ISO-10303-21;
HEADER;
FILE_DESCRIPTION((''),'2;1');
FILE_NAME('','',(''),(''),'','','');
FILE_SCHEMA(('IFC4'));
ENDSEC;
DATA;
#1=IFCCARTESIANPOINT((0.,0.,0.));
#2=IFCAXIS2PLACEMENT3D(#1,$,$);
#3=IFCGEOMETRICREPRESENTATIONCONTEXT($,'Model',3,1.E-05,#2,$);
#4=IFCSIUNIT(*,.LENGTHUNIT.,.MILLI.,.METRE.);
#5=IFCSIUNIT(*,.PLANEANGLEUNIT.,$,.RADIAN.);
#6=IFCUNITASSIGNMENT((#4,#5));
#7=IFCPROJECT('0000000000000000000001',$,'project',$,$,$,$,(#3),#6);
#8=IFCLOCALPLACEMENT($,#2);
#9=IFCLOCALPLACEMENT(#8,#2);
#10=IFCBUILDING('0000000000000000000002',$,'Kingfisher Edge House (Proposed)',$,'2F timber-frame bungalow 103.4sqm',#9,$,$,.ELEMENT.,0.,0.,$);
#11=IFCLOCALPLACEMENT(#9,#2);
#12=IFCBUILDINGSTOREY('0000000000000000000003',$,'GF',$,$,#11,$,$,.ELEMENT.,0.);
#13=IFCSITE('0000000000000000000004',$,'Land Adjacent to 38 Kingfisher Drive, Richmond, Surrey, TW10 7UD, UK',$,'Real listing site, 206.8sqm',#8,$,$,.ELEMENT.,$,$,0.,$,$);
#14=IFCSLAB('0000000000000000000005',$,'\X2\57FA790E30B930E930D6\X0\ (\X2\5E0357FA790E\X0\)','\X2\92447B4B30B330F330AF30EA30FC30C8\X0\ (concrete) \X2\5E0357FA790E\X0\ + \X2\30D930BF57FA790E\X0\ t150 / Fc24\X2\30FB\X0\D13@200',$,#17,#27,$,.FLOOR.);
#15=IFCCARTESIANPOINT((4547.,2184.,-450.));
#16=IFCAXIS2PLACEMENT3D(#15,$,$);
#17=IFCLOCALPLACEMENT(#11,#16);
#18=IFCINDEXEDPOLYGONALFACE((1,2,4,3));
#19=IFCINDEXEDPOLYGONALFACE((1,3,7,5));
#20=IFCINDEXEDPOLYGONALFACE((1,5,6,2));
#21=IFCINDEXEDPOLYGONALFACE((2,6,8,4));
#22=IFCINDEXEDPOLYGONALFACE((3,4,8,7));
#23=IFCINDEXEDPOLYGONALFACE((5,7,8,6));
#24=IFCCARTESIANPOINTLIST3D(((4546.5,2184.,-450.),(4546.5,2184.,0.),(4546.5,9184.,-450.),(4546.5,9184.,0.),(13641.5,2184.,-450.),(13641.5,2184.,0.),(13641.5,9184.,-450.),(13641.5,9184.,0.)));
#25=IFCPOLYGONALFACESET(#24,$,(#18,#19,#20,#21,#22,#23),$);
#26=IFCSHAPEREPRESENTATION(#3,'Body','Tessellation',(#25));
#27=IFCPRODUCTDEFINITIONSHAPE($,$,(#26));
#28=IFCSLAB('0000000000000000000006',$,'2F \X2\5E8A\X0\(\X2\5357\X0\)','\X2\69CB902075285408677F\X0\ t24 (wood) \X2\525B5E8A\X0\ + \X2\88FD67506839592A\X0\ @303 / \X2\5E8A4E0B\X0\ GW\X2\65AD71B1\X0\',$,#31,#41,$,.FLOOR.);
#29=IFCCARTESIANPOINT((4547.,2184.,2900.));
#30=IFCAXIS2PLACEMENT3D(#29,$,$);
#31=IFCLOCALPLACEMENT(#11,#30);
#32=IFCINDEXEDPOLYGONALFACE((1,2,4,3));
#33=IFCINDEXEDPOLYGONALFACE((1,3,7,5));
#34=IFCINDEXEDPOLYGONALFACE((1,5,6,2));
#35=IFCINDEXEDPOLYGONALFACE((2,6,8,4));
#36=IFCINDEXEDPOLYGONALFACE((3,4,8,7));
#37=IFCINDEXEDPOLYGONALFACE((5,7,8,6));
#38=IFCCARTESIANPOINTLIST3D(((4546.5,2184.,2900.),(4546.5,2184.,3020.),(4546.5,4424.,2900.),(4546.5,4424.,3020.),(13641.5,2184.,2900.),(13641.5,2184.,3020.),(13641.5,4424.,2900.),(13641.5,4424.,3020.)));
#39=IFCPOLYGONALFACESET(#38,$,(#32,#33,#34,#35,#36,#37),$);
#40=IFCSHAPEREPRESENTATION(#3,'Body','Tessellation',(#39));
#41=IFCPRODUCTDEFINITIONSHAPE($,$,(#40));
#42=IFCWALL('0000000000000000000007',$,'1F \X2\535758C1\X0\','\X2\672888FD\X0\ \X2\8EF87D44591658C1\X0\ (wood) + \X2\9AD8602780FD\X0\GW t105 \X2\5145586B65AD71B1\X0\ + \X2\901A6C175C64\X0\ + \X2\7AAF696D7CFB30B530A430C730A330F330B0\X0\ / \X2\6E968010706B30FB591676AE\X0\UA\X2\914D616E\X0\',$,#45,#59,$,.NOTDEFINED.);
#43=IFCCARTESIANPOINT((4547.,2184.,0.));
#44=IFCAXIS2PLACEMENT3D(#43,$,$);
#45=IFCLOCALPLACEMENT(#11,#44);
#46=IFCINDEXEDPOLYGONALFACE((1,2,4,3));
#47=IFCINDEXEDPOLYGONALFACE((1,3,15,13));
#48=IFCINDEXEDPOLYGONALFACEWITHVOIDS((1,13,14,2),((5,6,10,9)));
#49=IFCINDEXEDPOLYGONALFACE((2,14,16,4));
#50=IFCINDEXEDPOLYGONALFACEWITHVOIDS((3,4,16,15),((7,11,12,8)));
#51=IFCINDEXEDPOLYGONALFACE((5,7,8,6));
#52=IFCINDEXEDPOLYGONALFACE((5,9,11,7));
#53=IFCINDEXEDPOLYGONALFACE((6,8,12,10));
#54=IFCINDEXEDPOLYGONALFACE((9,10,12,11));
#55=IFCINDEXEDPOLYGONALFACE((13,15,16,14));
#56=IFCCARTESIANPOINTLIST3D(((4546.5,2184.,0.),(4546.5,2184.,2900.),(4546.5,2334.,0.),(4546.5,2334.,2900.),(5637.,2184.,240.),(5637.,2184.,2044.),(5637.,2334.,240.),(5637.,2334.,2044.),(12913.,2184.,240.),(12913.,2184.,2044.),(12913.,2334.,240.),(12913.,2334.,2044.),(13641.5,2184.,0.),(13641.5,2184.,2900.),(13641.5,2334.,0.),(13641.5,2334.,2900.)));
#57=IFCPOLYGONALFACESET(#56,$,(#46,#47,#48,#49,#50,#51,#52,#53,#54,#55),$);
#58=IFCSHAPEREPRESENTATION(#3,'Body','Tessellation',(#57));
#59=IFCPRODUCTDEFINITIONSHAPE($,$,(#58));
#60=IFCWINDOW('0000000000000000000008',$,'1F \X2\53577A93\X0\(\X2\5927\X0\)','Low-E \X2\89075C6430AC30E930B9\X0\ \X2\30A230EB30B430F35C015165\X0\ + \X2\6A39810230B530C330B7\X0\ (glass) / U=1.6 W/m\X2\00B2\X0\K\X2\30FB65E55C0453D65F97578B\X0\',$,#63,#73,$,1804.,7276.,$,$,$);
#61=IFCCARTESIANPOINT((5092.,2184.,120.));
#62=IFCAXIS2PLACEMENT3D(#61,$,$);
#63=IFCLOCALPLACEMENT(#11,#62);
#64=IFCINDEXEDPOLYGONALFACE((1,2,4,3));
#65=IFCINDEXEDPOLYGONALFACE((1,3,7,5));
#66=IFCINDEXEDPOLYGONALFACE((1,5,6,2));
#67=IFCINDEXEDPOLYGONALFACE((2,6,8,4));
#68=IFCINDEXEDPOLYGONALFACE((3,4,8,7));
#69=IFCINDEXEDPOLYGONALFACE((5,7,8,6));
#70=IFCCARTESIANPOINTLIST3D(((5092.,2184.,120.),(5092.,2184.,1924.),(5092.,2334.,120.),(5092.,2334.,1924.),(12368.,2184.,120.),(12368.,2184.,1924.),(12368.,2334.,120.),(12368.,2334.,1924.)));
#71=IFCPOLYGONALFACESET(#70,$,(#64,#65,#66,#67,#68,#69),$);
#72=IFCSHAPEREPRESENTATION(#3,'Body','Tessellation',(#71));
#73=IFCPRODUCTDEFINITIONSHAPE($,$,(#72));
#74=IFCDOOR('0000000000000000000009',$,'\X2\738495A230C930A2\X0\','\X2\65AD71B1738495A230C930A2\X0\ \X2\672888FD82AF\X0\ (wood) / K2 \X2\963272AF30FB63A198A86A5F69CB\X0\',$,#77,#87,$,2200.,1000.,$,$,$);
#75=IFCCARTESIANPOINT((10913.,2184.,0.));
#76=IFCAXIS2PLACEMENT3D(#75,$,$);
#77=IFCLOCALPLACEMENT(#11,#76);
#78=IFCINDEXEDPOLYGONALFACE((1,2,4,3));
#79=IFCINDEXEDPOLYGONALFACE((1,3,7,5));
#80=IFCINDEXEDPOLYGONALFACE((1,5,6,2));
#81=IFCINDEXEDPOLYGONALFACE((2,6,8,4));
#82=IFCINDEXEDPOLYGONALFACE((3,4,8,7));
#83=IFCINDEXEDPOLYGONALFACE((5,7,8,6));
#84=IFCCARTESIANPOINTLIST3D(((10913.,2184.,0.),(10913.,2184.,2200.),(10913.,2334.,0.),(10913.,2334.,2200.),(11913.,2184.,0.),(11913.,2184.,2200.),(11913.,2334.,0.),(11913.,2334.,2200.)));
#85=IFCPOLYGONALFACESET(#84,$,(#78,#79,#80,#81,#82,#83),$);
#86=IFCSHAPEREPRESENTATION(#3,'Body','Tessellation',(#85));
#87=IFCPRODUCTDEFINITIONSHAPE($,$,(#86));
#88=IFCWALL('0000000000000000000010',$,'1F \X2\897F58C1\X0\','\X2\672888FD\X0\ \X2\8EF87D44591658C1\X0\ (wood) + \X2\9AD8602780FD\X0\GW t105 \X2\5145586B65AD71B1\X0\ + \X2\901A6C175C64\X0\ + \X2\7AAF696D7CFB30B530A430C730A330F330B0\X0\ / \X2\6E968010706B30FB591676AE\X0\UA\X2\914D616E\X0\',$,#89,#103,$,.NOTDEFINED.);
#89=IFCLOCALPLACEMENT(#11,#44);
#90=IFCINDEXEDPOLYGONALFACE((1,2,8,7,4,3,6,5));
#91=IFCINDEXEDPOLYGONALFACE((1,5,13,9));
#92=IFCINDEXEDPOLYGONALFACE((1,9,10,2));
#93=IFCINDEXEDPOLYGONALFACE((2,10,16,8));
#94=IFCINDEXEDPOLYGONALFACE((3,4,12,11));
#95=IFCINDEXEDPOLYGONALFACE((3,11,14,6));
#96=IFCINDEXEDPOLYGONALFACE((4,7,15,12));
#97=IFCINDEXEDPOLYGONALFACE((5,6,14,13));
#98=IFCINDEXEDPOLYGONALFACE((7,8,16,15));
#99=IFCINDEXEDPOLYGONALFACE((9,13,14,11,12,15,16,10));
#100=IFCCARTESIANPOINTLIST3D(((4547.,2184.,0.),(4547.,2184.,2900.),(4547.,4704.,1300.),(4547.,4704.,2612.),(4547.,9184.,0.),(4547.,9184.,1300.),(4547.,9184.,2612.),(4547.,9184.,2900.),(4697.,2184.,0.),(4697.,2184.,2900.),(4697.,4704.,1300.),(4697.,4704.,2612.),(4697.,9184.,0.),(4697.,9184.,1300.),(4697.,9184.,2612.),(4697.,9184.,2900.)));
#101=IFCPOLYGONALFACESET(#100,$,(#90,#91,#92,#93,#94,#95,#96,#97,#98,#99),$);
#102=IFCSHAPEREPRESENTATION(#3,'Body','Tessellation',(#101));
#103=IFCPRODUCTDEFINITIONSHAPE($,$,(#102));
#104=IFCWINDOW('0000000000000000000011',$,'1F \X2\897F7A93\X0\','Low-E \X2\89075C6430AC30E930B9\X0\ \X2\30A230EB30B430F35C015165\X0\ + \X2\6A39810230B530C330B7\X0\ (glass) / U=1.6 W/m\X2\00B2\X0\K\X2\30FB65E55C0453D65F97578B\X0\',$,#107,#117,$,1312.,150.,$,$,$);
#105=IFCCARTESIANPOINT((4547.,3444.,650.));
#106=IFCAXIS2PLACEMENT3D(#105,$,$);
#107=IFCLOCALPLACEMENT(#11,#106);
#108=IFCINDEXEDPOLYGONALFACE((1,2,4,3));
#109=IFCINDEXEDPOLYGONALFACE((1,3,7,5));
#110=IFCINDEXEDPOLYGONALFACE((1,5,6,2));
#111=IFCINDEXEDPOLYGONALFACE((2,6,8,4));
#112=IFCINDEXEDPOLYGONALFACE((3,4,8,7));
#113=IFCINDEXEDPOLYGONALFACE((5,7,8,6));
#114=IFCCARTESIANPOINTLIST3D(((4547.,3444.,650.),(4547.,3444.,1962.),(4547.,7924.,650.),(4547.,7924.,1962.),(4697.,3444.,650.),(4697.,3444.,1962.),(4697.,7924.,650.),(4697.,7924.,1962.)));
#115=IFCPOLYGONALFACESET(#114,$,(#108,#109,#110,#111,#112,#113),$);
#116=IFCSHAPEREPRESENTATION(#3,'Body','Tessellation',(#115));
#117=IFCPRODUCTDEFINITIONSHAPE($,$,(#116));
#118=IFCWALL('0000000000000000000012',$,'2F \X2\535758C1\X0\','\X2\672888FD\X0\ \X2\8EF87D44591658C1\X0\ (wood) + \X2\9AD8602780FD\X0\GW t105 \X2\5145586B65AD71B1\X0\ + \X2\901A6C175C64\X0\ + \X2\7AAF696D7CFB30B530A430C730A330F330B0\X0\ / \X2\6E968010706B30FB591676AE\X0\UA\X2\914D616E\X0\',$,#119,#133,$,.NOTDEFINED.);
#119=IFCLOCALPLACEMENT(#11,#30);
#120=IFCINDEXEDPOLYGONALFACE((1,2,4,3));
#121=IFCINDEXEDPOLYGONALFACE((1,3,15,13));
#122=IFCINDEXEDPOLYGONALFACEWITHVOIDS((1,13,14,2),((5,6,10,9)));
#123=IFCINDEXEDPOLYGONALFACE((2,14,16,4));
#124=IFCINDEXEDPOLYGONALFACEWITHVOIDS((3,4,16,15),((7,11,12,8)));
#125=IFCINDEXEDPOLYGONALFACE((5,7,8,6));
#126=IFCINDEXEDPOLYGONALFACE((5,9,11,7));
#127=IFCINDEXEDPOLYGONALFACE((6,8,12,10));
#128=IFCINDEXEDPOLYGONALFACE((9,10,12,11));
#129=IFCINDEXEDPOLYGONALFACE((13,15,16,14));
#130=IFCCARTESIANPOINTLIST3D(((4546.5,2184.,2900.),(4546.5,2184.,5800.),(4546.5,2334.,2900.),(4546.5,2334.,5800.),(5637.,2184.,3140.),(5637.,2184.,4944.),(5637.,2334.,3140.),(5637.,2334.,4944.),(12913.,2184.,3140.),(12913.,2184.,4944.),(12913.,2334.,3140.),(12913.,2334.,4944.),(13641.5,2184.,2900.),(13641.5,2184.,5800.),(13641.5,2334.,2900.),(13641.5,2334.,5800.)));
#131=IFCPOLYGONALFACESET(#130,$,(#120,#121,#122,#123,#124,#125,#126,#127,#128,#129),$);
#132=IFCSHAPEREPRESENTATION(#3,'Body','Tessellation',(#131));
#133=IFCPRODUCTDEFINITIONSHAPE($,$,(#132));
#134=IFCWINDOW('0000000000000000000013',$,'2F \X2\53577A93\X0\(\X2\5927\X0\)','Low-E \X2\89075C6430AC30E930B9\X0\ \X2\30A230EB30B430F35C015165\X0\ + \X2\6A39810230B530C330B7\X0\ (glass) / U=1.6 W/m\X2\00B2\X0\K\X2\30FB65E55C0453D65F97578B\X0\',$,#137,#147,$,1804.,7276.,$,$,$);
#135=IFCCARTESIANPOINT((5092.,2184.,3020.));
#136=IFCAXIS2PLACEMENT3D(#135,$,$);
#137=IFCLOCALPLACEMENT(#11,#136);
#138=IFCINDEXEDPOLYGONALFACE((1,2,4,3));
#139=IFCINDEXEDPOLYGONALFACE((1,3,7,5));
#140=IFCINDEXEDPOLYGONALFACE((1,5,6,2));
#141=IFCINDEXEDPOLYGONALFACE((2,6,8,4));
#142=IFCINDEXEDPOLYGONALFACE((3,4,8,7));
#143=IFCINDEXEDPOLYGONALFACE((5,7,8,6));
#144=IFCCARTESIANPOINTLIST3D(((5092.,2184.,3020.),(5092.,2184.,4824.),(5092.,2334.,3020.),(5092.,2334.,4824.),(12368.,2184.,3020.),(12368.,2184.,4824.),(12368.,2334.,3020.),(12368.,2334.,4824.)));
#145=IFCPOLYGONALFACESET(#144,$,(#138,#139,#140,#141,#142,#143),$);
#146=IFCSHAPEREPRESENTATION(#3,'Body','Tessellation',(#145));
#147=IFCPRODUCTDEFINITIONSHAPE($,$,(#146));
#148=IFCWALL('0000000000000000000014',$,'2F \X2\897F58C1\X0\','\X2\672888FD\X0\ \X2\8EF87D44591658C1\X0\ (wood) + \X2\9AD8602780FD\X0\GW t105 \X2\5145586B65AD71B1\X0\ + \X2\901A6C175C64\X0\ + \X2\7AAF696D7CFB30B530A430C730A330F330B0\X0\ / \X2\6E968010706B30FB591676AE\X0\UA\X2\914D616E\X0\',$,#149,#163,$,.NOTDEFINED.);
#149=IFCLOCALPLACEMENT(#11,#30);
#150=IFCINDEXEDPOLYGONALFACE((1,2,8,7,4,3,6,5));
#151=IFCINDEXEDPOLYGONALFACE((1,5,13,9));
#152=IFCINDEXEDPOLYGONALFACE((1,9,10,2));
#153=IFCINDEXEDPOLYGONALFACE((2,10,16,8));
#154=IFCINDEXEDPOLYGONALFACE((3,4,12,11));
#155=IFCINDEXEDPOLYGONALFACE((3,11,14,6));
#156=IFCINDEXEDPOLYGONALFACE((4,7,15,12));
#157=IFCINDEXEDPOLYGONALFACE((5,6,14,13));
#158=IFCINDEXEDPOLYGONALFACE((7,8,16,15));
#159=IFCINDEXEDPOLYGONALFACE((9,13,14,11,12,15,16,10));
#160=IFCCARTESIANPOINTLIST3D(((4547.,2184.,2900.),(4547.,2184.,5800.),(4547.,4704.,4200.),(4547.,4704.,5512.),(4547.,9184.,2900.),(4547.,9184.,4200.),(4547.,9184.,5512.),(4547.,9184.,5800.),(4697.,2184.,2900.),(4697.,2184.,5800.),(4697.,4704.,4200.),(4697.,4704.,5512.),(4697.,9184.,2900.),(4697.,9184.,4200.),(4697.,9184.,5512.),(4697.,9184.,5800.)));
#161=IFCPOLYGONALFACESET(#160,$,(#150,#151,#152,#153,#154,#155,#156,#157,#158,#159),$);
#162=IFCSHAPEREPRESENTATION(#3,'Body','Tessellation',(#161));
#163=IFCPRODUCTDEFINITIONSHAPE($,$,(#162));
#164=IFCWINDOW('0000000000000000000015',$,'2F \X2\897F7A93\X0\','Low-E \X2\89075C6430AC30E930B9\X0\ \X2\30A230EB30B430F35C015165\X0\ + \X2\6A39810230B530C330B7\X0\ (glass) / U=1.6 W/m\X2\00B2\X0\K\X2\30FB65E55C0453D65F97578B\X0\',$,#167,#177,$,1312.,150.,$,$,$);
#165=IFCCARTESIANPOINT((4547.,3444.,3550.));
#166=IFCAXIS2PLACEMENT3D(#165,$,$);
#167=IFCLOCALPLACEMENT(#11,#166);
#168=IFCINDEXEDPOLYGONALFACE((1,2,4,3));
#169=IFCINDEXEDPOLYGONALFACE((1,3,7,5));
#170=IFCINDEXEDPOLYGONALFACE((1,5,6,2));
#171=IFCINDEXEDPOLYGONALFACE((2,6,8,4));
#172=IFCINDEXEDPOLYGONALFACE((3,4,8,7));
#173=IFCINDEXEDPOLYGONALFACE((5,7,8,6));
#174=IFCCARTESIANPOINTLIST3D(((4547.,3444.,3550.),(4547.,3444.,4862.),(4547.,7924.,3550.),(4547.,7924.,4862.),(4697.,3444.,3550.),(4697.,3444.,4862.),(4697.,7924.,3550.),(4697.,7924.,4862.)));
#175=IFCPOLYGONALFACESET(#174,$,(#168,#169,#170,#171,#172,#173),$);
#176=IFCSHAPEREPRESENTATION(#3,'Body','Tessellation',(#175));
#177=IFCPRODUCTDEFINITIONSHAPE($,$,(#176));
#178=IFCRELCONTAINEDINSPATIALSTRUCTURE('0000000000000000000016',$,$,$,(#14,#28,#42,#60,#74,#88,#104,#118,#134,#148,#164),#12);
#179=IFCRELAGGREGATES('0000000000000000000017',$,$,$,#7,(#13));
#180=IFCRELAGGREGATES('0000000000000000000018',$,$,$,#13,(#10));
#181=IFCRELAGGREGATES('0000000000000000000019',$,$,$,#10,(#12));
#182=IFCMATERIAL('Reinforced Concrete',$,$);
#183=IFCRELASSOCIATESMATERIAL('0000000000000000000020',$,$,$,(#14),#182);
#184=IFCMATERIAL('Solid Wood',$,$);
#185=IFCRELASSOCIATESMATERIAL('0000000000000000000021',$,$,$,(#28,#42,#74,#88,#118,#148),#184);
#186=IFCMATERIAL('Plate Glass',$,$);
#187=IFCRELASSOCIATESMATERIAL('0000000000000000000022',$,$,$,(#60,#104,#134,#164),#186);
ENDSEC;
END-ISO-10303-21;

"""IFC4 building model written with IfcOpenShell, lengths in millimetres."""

from ifc_helpers import new_model, si_unit, frame, frame_2d, origin, place, context, project, spatial, rectangle, extrude, material, element, fill, save


model = new_model("IFC4")

# Units and contexts
model_context = context("Model", 3, precision=1e-05, world=origin())
ifc_project = project(units=[si_unit("LENGTHUNIT", "METRE", prefix="MILLI"), si_unit("PLANEANGLEUNIT", "RADIAN")], contexts=[model_context])

# Site, building, storey
site_placement = place(None, origin())
site = spatial("IfcSite", under=ifc_project, at=site_placement, Name="Land Adjacent to 38 Kingfisher Drive, Richmond, Surrey, TW10 7UD, UK", ObjectType="Real listing site, 206.8sqm", CompositionType="ELEMENT", RefElevation=0.0)
building_placement = place(site_placement, origin())
building = spatial("IfcBuilding", under=site, at=building_placement, Name="Kingfisher Edge House (Proposed)", ObjectType="2F timber-frame bungalow 103.4sqm", CompositionType="ELEMENT", ElevationOfRefHeight=0.0, ElevationOfTerrain=0.0)
storey_placement = place(building_placement, origin())
storey = spatial("IfcBuildingStorey", under=building, at=storey_placement, Name="GF", CompositionType="ELEMENT", Elevation=0.0)

# Slabs
ifc_material_1 = material(Name="Reinforced Concrete")
slab_1_placement = place(storey_placement, frame((4547.0, 2184.0, -450.0)))
element("IfcSlab", 1, at=slab_1_placement, inside=storey, material=ifc_material_1, Name="基礎スラブ (布基礎)", Description="鉄筋コンクリート (concrete) 布基礎 + ベタ基礎 t150 / Fc24・D13@200", PredefinedType="FLOOR", context=model_context, shape_type="SweptSolid", body=[
    extrude(rectangle(XDim=9095.0, YDim=7000.0, at=frame_2d((4547.0, 3500.0))), frame((4547.0, 2184.0, -450.0)), (0.0, 0.0, 1.0), 450.0),
])
ifc_material_2 = material(Name="Solid Wood")
slab_2_placement = place(storey_placement, frame((4547.0, 2184.0, 2900.0)))
element("IfcSlab", 2, at=slab_2_placement, inside=storey, material=ifc_material_2, Name="2F 床(南)", Description="構造用合板 t24 (wood) 剛床 + 製材根太 @303 / 床下 GW断熱", PredefinedType="FLOOR", context=model_context, shape_type="SweptSolid", body=[
    extrude(rectangle(XDim=9095.0, YDim=2240.0, at=frame_2d((4547.0, 1120.0))), frame((4547.0, 2184.0, 2900.0)), (0.0, 0.0, 1.0), 120.0),
])

# Wall, openings, window, door
wall_1_placement = place(storey_placement, frame((4547.0, 2184.0, 0.0)))
wall_1 = element("IfcWall", 3, at=wall_1_placement, inside=storey, material=ifc_material_2, Name="1F 南壁", Description="木製 軸組外壁 (wood) + 高性能GW t105 充填断熱 + 通気層 + 窯業系サイディング / 準耐火・外皮UA配慮", PredefinedType="NOTDEFINED", context=model_context, shape_type="SweptSolid", body=[
    extrude(rectangle(XDim=9095.0, YDim=150.0, at=frame_2d((4547.0, 75.0))), frame((4547.0, 2184.0, 0.0)), (0.0, 0.0, 1.0), 2900.0),
])
opening_1_placement = place(storey_placement, frame((5092.0, 2184.0, 120.0)))
opening_1 = element("IfcOpeningElement", 4, at=opening_1_placement, cuts=wall_1, PredefinedType="NOTDEFINED", context=model_context, shape_type="SweptSolid", body=[
    extrude(rectangle(XDim=7276.0, YDim=150.0, at=frame_2d((3638.0, 75.0))), frame((5092.0, 2184.0, 120.0)), (0.0, 0.0, 1.0), 1804.0),
])
opening_2_placement = place(storey_placement, frame((10913.0, 2184.0, 0.0)))
opening_2 = element("IfcOpeningElement", 5, at=opening_2_placement, cuts=wall_1, PredefinedType="NOTDEFINED", context=model_context, shape_type="SweptSolid", body=[
    extrude(rectangle(XDim=1000.0, YDim=150.0, at=frame_2d((500.0, 75.0))), frame((10913.0, 2184.0, 0.0)), (0.0, 0.0, 1.0), 2200.0),
])
ifc_material_3 = material(Name="Plate Glass")
window_1_placement = place(storey_placement, frame((5092.0, 2184.0, 120.0)))
window_1 = element("IfcWindow", 6, at=window_1_placement, inside=storey, material=ifc_material_3, Name="1F 南窓(大)", Description="Low-E 複層ガラス アルゴン封入 + 樹脂サッシ (glass) / U=1.6 W/m²K・日射取得型", OverallHeight=1804.0, OverallWidth=7276.0, context=model_context, shape_type="SweptSolid", body=[
    extrude(rectangle(XDim=7276.0, YDim=150.0, at=frame_2d((3638.0, 75.0))), frame((5092.0, 2184.0, 120.0)), (0.0, 0.0, 1.0), 1804.0),
])
fill(opening_1, window_1)
door_placement = place(storey_placement, frame((10913.0, 2184.0, 0.0)))
door = element("IfcDoor", 7, at=door_placement, inside=storey, material=ifc_material_2, Name="玄関ドア", Description="断熱玄関ドア 木製芯 (wood) / K2 防犯・採風機構", OverallHeight=2200.0, OverallWidth=1000.0, context=model_context, shape_type="SweptSolid", body=[
    extrude(rectangle(XDim=1000.0, YDim=150.0, at=frame_2d((500.0, 75.0))), frame((10913.0, 2184.0, 0.0)), (0.0, 0.0, 1.0), 2200.0),
])
fill(opening_2, door)

# Walls, openings, windows
wall_2_placement = place(storey_placement, frame((4547.0, 2184.0, 0.0)))
wall_2 = element("IfcWall", 8, at=wall_2_placement, inside=storey, material=ifc_material_2, Name="1F 西壁", Description="木製 軸組外壁 (wood) + 高性能GW t105 充填断熱 + 通気層 + 窯業系サイディング / 準耐火・外皮UA配慮", PredefinedType="NOTDEFINED", context=model_context, shape_type="SweptSolid", body=[
    extrude(rectangle(XDim=150.0, YDim=7000.0, at=frame_2d((75.0, 3500.0))), frame((4547.0, 2184.0, 0.0)), (0.0, 0.0, 1.0), 2900.0),
])
opening_3_placement = place(storey_placement, frame((4547.0, 3444.0, 650.0)))
opening_3 = element("IfcOpeningElement", 9, at=opening_3_placement, cuts=wall_2, PredefinedType="NOTDEFINED", context=model_context, shape_type="SweptSolid", body=[
    extrude(rectangle(XDim=150.0, YDim=4480.0, at=frame_2d((75.0, 2240.0))), frame((4547.0, 3444.0, 650.0)), (0.0, 0.0, 1.0), 1312.0),
])
window_2_placement = place(storey_placement, frame((4547.0, 3444.0, 650.0)))
window_2 = element("IfcWindow", 10, at=window_2_placement, inside=storey, material=ifc_material_3, Name="1F 西窓", Description="Low-E 複層ガラス アルゴン封入 + 樹脂サッシ (glass) / U=1.6 W/m²K・日射取得型", OverallHeight=1312.0, OverallWidth=150.0, context=model_context, shape_type="SweptSolid", body=[
    extrude(rectangle(XDim=150.0, YDim=4480.0, at=frame_2d((75.0, 2240.0))), frame((4547.0, 3444.0, 650.0)), (0.0, 0.0, 1.0), 1312.0),
])
fill(opening_3, window_2)
wall_3_placement = place(storey_placement, frame((4547.0, 2184.0, 2900.0)))
wall_3 = element("IfcWall", 11, at=wall_3_placement, inside=storey, material=ifc_material_2, Name="2F 南壁", Description="木製 軸組外壁 (wood) + 高性能GW t105 充填断熱 + 通気層 + 窯業系サイディング / 準耐火・外皮UA配慮", PredefinedType="NOTDEFINED", context=model_context, shape_type="SweptSolid", body=[
    extrude(rectangle(XDim=9095.0, YDim=150.0, at=frame_2d((4547.0, 75.0))), frame((4547.0, 2184.0, 2900.0)), (0.0, 0.0, 1.0), 2900.0),
])
opening_4_placement = place(storey_placement, frame((5092.0, 2184.0, 3020.0)))
opening_4 = element("IfcOpeningElement", 12, at=opening_4_placement, cuts=wall_3, PredefinedType="NOTDEFINED", context=model_context, shape_type="SweptSolid", body=[
    extrude(rectangle(XDim=7276.0, YDim=150.0, at=frame_2d((3638.0, 75.0))), frame((5092.0, 2184.0, 3020.0)), (0.0, 0.0, 1.0), 1804.0),
])
window_3_placement = place(storey_placement, frame((5092.0, 2184.0, 3020.0)))
window_3 = element("IfcWindow", 13, at=window_3_placement, inside=storey, material=ifc_material_3, Name="2F 南窓(大)", Description="Low-E 複層ガラス アルゴン封入 + 樹脂サッシ (glass) / U=1.6 W/m²K・日射取得型", OverallHeight=1804.0, OverallWidth=7276.0, context=model_context, shape_type="SweptSolid", body=[
    extrude(rectangle(XDim=7276.0, YDim=150.0, at=frame_2d((3638.0, 75.0))), frame((5092.0, 2184.0, 3020.0)), (0.0, 0.0, 1.0), 1804.0),
])
fill(opening_4, window_3)
wall_4_placement = place(storey_placement, frame((4547.0, 2184.0, 2900.0)))
wall_4 = element("IfcWall", 14, at=wall_4_placement, inside=storey, material=ifc_material_2, Name="2F 西壁", Description="木製 軸組外壁 (wood) + 高性能GW t105 充填断熱 + 通気層 + 窯業系サイディング / 準耐火・外皮UA配慮", PredefinedType="NOTDEFINED", context=model_context, shape_type="SweptSolid", body=[
    extrude(rectangle(XDim=150.0, YDim=7000.0, at=frame_2d((75.0, 3500.0))), frame((4547.0, 2184.0, 2900.0)), (0.0, 0.0, 1.0), 2900.0),
])
opening_5_placement = place(storey_placement, frame((4547.0, 3444.0, 3550.0)))
opening_5 = element("IfcOpeningElement", 15, at=opening_5_placement, cuts=wall_4, PredefinedType="NOTDEFINED", context=model_context, shape_type="SweptSolid", body=[
    extrude(rectangle(XDim=150.0, YDim=4480.0, at=frame_2d((75.0, 2240.0))), frame((4547.0, 3444.0, 3550.0)), (0.0, 0.0, 1.0), 1312.0),
])
window_4_placement = place(storey_placement, frame((4547.0, 3444.0, 3550.0)))
window_4 = element("IfcWindow", 16, at=window_4_placement, inside=storey, material=ifc_material_3, Name="2F 西窓", Description="Low-E 複層ガラス アルゴン封入 + 樹脂サッシ (glass) / U=1.6 W/m²K・日射取得型", OverallHeight=1312.0, OverallWidth=150.0, context=model_context, shape_type="SweptSolid", body=[
    extrude(rectangle(XDim=150.0, YDim=4480.0, at=frame_2d((75.0, 2240.0))), frame((4547.0, 3444.0, 3550.0)), (0.0, 0.0, 1.0), 1312.0),
])
fill(opening_5, window_4)

save(model, "model.ifc")
